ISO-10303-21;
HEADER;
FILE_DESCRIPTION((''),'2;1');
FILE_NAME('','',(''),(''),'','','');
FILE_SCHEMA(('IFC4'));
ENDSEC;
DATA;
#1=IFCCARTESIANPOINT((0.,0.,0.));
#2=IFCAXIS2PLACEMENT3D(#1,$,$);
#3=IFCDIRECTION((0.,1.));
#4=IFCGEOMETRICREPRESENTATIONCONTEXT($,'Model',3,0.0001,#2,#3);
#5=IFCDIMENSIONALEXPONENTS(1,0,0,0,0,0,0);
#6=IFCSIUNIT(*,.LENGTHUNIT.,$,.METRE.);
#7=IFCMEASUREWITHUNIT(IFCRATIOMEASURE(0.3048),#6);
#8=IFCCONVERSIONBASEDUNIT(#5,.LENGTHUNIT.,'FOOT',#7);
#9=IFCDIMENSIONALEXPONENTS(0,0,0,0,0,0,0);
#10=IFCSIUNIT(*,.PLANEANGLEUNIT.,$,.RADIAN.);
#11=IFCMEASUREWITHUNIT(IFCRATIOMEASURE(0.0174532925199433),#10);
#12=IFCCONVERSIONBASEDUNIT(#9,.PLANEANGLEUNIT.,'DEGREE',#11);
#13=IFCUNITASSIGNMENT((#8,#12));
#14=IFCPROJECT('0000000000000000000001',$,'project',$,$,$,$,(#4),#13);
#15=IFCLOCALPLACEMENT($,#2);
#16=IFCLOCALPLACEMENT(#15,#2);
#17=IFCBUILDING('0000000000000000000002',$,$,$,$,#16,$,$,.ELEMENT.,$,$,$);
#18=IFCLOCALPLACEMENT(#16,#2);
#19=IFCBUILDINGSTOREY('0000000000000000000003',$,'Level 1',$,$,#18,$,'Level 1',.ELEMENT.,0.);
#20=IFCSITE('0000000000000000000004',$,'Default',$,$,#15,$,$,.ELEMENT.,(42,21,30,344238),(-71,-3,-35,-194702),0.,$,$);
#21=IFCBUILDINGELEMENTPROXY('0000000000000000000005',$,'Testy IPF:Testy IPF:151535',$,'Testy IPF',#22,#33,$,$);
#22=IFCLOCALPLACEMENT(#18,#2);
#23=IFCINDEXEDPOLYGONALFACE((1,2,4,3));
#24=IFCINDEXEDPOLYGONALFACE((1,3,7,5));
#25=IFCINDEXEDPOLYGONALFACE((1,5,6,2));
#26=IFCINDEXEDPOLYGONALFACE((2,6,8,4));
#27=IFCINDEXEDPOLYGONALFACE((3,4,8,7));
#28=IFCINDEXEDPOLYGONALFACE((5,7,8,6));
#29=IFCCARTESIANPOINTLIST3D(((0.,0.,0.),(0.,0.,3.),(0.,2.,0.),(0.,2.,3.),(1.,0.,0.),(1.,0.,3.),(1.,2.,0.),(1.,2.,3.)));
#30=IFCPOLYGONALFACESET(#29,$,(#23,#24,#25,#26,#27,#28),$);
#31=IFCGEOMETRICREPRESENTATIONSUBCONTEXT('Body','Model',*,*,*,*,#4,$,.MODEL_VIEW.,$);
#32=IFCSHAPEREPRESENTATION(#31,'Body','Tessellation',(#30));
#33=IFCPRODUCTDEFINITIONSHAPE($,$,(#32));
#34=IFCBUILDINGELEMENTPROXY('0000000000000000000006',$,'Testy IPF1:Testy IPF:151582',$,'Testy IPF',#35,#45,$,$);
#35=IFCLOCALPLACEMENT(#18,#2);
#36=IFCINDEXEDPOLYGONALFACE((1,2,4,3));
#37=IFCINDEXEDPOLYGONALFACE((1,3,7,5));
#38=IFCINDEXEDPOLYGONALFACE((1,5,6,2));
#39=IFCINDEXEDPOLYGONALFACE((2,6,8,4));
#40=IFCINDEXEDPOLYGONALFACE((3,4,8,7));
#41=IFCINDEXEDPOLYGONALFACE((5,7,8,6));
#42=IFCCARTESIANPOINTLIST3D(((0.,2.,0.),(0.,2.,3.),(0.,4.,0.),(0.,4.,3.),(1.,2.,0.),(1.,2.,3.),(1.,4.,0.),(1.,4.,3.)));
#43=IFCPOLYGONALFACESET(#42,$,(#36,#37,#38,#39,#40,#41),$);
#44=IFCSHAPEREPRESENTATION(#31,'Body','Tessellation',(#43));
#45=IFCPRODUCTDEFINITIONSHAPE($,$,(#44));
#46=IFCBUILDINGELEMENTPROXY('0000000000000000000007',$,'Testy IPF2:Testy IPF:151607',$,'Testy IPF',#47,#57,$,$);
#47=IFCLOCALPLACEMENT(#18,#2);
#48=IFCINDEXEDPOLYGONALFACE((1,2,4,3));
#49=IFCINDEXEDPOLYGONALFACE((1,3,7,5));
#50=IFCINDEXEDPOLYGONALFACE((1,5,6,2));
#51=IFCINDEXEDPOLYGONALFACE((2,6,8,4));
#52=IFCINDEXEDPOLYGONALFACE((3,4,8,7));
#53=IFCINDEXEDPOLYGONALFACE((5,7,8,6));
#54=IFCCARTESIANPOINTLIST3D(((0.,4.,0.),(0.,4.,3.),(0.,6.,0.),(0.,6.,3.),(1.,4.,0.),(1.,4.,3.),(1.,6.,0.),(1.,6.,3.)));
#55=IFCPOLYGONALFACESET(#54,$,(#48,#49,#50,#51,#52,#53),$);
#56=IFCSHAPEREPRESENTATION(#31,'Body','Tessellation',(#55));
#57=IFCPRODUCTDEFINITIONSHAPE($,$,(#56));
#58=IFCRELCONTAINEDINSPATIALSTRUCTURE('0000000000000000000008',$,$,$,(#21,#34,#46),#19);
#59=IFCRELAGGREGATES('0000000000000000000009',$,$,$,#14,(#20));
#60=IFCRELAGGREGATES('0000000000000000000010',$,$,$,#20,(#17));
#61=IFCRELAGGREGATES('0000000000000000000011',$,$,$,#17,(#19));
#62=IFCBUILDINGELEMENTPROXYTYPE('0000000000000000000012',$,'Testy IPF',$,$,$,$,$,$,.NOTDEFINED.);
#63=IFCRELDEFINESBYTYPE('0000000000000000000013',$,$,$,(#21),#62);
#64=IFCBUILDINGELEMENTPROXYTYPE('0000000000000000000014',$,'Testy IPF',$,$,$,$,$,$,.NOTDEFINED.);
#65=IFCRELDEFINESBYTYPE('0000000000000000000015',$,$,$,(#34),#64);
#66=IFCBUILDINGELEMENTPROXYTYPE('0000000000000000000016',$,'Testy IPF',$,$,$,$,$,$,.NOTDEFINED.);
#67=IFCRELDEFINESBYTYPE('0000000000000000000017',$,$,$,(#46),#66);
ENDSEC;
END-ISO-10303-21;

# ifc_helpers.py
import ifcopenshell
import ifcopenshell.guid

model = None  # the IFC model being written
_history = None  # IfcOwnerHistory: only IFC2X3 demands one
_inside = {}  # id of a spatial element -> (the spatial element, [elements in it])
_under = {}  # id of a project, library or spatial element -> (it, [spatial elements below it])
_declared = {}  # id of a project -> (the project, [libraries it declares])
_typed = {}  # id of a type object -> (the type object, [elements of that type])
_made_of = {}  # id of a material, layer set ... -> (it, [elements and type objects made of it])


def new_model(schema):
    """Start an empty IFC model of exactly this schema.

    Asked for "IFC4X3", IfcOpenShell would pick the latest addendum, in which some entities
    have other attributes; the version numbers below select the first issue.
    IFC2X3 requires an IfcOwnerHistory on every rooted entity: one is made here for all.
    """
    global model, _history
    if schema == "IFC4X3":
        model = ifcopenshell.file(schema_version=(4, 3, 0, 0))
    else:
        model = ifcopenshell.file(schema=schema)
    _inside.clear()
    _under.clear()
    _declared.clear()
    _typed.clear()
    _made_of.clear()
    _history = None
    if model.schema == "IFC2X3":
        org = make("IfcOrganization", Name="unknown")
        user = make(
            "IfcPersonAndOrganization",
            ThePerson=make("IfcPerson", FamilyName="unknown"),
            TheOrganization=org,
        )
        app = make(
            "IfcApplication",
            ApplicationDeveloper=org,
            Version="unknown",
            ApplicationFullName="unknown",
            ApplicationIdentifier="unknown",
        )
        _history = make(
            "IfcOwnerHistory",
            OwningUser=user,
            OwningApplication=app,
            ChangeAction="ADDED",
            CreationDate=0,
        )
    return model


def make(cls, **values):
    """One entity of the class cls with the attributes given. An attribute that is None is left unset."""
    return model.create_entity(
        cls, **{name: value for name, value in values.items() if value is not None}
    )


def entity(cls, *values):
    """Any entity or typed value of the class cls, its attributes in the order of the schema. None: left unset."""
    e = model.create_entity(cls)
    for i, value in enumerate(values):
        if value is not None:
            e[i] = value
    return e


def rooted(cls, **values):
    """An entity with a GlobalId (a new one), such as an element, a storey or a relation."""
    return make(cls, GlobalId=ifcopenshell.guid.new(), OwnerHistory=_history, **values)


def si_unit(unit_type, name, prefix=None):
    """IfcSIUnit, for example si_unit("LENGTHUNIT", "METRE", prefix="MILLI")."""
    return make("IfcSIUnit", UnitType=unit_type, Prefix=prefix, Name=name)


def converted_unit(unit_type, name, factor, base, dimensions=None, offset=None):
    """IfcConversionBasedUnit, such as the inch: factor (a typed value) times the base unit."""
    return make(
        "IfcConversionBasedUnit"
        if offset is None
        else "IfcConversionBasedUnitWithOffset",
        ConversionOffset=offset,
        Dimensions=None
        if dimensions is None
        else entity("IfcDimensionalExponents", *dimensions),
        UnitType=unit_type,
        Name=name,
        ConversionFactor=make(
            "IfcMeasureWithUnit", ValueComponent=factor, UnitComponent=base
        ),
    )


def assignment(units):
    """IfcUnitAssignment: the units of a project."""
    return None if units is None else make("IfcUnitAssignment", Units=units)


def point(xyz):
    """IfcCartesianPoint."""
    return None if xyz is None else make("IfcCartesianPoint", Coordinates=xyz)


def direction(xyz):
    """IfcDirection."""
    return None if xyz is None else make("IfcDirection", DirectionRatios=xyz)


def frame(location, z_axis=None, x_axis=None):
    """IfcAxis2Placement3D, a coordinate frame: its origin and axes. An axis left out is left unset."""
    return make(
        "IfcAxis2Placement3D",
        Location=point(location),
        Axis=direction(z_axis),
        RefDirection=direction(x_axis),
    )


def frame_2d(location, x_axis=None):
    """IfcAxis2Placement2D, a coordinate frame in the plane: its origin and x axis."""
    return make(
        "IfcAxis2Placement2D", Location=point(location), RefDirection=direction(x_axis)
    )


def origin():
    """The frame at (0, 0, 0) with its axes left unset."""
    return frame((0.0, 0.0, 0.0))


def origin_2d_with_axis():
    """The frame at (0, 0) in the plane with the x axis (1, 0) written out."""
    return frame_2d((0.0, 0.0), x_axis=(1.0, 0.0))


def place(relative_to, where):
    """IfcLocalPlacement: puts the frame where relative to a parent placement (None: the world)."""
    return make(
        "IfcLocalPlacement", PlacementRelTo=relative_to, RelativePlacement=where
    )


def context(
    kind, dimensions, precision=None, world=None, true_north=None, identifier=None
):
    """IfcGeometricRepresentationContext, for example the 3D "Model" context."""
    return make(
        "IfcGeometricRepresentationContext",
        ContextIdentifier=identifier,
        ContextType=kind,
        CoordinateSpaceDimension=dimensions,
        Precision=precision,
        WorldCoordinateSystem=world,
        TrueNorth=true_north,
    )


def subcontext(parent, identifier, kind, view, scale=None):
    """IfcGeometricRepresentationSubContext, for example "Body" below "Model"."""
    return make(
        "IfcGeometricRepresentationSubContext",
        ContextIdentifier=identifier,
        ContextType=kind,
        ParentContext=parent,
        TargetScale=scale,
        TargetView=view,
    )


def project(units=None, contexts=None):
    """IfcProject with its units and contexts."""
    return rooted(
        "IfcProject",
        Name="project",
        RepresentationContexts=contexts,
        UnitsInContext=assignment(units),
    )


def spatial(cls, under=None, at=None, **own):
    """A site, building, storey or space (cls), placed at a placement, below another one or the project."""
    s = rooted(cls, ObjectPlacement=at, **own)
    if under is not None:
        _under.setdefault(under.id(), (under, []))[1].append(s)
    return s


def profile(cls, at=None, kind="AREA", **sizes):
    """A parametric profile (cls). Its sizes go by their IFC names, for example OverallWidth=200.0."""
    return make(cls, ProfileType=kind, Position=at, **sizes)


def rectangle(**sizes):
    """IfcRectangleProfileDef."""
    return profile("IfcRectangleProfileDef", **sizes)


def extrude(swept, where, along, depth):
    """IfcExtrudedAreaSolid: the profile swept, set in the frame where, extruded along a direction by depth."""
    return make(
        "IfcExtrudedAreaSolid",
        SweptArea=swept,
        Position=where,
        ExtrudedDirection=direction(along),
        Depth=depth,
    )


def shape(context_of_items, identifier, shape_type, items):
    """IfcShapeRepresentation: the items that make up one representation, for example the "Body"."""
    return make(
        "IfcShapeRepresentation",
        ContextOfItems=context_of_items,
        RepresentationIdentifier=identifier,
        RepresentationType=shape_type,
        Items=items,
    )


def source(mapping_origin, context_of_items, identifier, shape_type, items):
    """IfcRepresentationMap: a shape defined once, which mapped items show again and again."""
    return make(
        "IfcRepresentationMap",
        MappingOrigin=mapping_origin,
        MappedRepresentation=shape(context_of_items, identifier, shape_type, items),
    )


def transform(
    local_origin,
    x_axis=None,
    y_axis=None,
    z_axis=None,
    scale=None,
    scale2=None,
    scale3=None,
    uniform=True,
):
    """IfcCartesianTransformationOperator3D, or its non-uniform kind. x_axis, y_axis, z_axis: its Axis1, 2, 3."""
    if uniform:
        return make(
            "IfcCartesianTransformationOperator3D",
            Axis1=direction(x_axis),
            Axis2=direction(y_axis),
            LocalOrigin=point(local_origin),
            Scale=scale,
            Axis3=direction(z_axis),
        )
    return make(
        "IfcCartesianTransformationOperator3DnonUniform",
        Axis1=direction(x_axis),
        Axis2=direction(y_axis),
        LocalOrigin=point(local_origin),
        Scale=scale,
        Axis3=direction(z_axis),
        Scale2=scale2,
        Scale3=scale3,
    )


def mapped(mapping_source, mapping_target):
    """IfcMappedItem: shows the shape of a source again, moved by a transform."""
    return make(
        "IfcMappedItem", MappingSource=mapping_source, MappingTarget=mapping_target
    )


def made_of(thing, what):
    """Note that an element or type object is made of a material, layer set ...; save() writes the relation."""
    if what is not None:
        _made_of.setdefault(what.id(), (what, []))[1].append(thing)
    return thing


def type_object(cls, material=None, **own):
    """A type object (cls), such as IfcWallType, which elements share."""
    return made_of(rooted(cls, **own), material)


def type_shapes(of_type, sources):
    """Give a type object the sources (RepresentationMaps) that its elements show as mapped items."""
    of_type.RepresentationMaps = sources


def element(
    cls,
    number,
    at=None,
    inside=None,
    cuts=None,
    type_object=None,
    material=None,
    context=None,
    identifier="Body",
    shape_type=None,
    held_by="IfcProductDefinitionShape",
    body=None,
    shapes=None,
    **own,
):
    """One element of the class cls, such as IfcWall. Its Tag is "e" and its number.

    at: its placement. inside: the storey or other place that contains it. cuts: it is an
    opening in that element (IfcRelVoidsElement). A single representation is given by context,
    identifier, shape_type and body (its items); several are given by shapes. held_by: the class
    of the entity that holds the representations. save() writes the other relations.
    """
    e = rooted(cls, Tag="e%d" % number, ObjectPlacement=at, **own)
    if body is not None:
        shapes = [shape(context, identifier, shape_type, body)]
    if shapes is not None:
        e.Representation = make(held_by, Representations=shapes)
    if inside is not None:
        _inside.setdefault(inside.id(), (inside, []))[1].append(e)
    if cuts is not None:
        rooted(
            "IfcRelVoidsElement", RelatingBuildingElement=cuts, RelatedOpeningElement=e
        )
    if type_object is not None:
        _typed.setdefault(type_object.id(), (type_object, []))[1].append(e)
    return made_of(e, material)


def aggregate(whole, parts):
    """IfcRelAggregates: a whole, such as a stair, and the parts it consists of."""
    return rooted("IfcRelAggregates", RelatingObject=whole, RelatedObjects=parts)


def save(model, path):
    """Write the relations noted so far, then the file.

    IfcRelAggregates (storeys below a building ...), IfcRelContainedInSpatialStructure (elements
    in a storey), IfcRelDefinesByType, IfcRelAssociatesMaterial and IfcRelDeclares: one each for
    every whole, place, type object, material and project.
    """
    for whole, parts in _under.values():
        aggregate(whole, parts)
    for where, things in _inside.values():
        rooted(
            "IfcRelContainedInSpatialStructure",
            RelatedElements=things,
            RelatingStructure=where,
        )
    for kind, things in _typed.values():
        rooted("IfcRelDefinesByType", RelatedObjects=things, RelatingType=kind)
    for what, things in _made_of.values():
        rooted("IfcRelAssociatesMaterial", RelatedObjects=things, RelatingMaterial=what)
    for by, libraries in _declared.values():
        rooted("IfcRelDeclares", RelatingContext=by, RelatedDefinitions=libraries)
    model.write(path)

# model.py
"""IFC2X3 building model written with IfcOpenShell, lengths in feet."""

from ifc_helpers import new_model, entity, si_unit, converted_unit, direction, frame, frame_2d, origin, origin_2d_with_axis, place, context, subcontext, project, spatial, rectangle, extrude, source, transform, mapped, type_object, type_shapes, element, save


model = new_model("IFC2X3")

# Units and contexts
model_context = context("Model", 3, precision=0.0001, world=origin(), true_north=direction((0.0, 1.0)))
body_context = subcontext(model_context, "Body", "Model", "MODEL_VIEW")
ifc_project = project(units=[converted_unit("LENGTHUNIT", "FOOT", entity("IfcRatioMeasure", 0.3048), si_unit("LENGTHUNIT", "METRE"), dimensions=[1, 0, 0, 0, 0, 0, 0]), converted_unit("PLANEANGLEUNIT", "DEGREE", entity("IfcRatioMeasure", 0.0174532925199433), si_unit("PLANEANGLEUNIT", "RADIAN"), dimensions=[0, 0, 0, 0, 0, 0, 0])], contexts=[model_context])

# Site, building, storey
site_placement = place(None, origin())
site = spatial("IfcSite", under=ifc_project, at=site_placement, Name="Default", CompositionType="ELEMENT", RefLatitude=(42, 21, 30, 344238), RefLongitude=(-71, -3, -35, -194702), RefElevation=0.0)
building_placement = place(site_placement, origin())
building = spatial("IfcBuilding", under=site, at=building_placement, CompositionType="ELEMENT")
storey_placement = place(building_placement, origin())
storey = spatial("IfcBuildingStorey", under=building, at=storey_placement, Name="Level 1", LongName="Level 1", CompositionType="ELEMENT", Elevation=0.0)

# Building element proxies
building_element_proxy_type_1 = type_object("IfcBuildingElementProxyType", Name="Testy IPF", PredefinedType="NOTDEFINED")
shared_shape_1 = source(origin(), body_context, "Body", "SweptSolid", [
    extrude(rectangle(XDim=2.0, YDim=1.0, at=frame_2d((0.0, 0.0), x_axis=(1.0, 0.0))), frame((0.5, 1.0, 0.0), z_axis=(0.0, 0.0, 1.0), x_axis=(0.0, 1.0, 0.0)), (0.0, 0.0, 1.0), 3.0),
])
type_shapes(building_element_proxy_type_1, [shared_shape_1])
proxy_1_placement = place(storey_placement, origin())
element("IfcBuildingElementProxy", 1, at=proxy_1_placement, inside=storey, type_object=building_element_proxy_type_1, Name="Testy IPF:Testy IPF:151535", ObjectType="Testy IPF", context=body_context, shape_type="MappedRepresentation", body=[
    mapped(shared_shape_1, transform((0.0, 0.0, 0.0), scale=1.0)),
])
building_element_proxy_type_2 = type_object("IfcBuildingElementProxyType", Name="Testy IPF", PredefinedType="NOTDEFINED")
shared_shape_2 = source(origin(), body_context, "Body", "SweptSolid", [
    extrude(rectangle(XDim=2.0, YDim=1.0, at=origin_2d_with_axis()), frame((0.5, 3.0, 0.0), z_axis=(0.0, 0.0, 1.0), x_axis=(0.0, 1.0, 0.0)), (0.0, 0.0, 1.0), 3.0),
])
type_shapes(building_element_proxy_type_2, [shared_shape_2])
proxy_2_placement = place(storey_placement, origin())
element("IfcBuildingElementProxy", 2, at=proxy_2_placement, inside=storey, type_object=building_element_proxy_type_2, Name="Testy IPF1:Testy IPF:151582", ObjectType="Testy IPF", context=body_context, shape_type="MappedRepresentation", body=[
    mapped(shared_shape_2, transform((0.0, 0.0, 0.0), scale=1.0)),
])
building_element_proxy_type_3 = type_object("IfcBuildingElementProxyType", Name="Testy IPF", PredefinedType="NOTDEFINED")
shared_shape_3 = source(origin(), body_context, "Body", "SweptSolid", [
    extrude(rectangle(XDim=2.0, YDim=1.0, at=origin_2d_with_axis()), frame((0.5, 5.0, 0.0), z_axis=(0.0, 0.0, 1.0), x_axis=(0.0, 1.0, 0.0)), (0.0, 0.0, 1.0), 3.0),
])
type_shapes(building_element_proxy_type_3, [shared_shape_3])
proxy_3_placement = place(storey_placement, origin())
element("IfcBuildingElementProxy", 3, at=proxy_3_placement, inside=storey, type_object=building_element_proxy_type_3, Name="Testy IPF2:Testy IPF:151607", ObjectType="Testy IPF", context=body_context, shape_type="MappedRepresentation", body=[
    mapped(shared_shape_3, transform((0.0, 0.0, 0.0), scale=1.0)),
])

save(model, "model.ifc")
